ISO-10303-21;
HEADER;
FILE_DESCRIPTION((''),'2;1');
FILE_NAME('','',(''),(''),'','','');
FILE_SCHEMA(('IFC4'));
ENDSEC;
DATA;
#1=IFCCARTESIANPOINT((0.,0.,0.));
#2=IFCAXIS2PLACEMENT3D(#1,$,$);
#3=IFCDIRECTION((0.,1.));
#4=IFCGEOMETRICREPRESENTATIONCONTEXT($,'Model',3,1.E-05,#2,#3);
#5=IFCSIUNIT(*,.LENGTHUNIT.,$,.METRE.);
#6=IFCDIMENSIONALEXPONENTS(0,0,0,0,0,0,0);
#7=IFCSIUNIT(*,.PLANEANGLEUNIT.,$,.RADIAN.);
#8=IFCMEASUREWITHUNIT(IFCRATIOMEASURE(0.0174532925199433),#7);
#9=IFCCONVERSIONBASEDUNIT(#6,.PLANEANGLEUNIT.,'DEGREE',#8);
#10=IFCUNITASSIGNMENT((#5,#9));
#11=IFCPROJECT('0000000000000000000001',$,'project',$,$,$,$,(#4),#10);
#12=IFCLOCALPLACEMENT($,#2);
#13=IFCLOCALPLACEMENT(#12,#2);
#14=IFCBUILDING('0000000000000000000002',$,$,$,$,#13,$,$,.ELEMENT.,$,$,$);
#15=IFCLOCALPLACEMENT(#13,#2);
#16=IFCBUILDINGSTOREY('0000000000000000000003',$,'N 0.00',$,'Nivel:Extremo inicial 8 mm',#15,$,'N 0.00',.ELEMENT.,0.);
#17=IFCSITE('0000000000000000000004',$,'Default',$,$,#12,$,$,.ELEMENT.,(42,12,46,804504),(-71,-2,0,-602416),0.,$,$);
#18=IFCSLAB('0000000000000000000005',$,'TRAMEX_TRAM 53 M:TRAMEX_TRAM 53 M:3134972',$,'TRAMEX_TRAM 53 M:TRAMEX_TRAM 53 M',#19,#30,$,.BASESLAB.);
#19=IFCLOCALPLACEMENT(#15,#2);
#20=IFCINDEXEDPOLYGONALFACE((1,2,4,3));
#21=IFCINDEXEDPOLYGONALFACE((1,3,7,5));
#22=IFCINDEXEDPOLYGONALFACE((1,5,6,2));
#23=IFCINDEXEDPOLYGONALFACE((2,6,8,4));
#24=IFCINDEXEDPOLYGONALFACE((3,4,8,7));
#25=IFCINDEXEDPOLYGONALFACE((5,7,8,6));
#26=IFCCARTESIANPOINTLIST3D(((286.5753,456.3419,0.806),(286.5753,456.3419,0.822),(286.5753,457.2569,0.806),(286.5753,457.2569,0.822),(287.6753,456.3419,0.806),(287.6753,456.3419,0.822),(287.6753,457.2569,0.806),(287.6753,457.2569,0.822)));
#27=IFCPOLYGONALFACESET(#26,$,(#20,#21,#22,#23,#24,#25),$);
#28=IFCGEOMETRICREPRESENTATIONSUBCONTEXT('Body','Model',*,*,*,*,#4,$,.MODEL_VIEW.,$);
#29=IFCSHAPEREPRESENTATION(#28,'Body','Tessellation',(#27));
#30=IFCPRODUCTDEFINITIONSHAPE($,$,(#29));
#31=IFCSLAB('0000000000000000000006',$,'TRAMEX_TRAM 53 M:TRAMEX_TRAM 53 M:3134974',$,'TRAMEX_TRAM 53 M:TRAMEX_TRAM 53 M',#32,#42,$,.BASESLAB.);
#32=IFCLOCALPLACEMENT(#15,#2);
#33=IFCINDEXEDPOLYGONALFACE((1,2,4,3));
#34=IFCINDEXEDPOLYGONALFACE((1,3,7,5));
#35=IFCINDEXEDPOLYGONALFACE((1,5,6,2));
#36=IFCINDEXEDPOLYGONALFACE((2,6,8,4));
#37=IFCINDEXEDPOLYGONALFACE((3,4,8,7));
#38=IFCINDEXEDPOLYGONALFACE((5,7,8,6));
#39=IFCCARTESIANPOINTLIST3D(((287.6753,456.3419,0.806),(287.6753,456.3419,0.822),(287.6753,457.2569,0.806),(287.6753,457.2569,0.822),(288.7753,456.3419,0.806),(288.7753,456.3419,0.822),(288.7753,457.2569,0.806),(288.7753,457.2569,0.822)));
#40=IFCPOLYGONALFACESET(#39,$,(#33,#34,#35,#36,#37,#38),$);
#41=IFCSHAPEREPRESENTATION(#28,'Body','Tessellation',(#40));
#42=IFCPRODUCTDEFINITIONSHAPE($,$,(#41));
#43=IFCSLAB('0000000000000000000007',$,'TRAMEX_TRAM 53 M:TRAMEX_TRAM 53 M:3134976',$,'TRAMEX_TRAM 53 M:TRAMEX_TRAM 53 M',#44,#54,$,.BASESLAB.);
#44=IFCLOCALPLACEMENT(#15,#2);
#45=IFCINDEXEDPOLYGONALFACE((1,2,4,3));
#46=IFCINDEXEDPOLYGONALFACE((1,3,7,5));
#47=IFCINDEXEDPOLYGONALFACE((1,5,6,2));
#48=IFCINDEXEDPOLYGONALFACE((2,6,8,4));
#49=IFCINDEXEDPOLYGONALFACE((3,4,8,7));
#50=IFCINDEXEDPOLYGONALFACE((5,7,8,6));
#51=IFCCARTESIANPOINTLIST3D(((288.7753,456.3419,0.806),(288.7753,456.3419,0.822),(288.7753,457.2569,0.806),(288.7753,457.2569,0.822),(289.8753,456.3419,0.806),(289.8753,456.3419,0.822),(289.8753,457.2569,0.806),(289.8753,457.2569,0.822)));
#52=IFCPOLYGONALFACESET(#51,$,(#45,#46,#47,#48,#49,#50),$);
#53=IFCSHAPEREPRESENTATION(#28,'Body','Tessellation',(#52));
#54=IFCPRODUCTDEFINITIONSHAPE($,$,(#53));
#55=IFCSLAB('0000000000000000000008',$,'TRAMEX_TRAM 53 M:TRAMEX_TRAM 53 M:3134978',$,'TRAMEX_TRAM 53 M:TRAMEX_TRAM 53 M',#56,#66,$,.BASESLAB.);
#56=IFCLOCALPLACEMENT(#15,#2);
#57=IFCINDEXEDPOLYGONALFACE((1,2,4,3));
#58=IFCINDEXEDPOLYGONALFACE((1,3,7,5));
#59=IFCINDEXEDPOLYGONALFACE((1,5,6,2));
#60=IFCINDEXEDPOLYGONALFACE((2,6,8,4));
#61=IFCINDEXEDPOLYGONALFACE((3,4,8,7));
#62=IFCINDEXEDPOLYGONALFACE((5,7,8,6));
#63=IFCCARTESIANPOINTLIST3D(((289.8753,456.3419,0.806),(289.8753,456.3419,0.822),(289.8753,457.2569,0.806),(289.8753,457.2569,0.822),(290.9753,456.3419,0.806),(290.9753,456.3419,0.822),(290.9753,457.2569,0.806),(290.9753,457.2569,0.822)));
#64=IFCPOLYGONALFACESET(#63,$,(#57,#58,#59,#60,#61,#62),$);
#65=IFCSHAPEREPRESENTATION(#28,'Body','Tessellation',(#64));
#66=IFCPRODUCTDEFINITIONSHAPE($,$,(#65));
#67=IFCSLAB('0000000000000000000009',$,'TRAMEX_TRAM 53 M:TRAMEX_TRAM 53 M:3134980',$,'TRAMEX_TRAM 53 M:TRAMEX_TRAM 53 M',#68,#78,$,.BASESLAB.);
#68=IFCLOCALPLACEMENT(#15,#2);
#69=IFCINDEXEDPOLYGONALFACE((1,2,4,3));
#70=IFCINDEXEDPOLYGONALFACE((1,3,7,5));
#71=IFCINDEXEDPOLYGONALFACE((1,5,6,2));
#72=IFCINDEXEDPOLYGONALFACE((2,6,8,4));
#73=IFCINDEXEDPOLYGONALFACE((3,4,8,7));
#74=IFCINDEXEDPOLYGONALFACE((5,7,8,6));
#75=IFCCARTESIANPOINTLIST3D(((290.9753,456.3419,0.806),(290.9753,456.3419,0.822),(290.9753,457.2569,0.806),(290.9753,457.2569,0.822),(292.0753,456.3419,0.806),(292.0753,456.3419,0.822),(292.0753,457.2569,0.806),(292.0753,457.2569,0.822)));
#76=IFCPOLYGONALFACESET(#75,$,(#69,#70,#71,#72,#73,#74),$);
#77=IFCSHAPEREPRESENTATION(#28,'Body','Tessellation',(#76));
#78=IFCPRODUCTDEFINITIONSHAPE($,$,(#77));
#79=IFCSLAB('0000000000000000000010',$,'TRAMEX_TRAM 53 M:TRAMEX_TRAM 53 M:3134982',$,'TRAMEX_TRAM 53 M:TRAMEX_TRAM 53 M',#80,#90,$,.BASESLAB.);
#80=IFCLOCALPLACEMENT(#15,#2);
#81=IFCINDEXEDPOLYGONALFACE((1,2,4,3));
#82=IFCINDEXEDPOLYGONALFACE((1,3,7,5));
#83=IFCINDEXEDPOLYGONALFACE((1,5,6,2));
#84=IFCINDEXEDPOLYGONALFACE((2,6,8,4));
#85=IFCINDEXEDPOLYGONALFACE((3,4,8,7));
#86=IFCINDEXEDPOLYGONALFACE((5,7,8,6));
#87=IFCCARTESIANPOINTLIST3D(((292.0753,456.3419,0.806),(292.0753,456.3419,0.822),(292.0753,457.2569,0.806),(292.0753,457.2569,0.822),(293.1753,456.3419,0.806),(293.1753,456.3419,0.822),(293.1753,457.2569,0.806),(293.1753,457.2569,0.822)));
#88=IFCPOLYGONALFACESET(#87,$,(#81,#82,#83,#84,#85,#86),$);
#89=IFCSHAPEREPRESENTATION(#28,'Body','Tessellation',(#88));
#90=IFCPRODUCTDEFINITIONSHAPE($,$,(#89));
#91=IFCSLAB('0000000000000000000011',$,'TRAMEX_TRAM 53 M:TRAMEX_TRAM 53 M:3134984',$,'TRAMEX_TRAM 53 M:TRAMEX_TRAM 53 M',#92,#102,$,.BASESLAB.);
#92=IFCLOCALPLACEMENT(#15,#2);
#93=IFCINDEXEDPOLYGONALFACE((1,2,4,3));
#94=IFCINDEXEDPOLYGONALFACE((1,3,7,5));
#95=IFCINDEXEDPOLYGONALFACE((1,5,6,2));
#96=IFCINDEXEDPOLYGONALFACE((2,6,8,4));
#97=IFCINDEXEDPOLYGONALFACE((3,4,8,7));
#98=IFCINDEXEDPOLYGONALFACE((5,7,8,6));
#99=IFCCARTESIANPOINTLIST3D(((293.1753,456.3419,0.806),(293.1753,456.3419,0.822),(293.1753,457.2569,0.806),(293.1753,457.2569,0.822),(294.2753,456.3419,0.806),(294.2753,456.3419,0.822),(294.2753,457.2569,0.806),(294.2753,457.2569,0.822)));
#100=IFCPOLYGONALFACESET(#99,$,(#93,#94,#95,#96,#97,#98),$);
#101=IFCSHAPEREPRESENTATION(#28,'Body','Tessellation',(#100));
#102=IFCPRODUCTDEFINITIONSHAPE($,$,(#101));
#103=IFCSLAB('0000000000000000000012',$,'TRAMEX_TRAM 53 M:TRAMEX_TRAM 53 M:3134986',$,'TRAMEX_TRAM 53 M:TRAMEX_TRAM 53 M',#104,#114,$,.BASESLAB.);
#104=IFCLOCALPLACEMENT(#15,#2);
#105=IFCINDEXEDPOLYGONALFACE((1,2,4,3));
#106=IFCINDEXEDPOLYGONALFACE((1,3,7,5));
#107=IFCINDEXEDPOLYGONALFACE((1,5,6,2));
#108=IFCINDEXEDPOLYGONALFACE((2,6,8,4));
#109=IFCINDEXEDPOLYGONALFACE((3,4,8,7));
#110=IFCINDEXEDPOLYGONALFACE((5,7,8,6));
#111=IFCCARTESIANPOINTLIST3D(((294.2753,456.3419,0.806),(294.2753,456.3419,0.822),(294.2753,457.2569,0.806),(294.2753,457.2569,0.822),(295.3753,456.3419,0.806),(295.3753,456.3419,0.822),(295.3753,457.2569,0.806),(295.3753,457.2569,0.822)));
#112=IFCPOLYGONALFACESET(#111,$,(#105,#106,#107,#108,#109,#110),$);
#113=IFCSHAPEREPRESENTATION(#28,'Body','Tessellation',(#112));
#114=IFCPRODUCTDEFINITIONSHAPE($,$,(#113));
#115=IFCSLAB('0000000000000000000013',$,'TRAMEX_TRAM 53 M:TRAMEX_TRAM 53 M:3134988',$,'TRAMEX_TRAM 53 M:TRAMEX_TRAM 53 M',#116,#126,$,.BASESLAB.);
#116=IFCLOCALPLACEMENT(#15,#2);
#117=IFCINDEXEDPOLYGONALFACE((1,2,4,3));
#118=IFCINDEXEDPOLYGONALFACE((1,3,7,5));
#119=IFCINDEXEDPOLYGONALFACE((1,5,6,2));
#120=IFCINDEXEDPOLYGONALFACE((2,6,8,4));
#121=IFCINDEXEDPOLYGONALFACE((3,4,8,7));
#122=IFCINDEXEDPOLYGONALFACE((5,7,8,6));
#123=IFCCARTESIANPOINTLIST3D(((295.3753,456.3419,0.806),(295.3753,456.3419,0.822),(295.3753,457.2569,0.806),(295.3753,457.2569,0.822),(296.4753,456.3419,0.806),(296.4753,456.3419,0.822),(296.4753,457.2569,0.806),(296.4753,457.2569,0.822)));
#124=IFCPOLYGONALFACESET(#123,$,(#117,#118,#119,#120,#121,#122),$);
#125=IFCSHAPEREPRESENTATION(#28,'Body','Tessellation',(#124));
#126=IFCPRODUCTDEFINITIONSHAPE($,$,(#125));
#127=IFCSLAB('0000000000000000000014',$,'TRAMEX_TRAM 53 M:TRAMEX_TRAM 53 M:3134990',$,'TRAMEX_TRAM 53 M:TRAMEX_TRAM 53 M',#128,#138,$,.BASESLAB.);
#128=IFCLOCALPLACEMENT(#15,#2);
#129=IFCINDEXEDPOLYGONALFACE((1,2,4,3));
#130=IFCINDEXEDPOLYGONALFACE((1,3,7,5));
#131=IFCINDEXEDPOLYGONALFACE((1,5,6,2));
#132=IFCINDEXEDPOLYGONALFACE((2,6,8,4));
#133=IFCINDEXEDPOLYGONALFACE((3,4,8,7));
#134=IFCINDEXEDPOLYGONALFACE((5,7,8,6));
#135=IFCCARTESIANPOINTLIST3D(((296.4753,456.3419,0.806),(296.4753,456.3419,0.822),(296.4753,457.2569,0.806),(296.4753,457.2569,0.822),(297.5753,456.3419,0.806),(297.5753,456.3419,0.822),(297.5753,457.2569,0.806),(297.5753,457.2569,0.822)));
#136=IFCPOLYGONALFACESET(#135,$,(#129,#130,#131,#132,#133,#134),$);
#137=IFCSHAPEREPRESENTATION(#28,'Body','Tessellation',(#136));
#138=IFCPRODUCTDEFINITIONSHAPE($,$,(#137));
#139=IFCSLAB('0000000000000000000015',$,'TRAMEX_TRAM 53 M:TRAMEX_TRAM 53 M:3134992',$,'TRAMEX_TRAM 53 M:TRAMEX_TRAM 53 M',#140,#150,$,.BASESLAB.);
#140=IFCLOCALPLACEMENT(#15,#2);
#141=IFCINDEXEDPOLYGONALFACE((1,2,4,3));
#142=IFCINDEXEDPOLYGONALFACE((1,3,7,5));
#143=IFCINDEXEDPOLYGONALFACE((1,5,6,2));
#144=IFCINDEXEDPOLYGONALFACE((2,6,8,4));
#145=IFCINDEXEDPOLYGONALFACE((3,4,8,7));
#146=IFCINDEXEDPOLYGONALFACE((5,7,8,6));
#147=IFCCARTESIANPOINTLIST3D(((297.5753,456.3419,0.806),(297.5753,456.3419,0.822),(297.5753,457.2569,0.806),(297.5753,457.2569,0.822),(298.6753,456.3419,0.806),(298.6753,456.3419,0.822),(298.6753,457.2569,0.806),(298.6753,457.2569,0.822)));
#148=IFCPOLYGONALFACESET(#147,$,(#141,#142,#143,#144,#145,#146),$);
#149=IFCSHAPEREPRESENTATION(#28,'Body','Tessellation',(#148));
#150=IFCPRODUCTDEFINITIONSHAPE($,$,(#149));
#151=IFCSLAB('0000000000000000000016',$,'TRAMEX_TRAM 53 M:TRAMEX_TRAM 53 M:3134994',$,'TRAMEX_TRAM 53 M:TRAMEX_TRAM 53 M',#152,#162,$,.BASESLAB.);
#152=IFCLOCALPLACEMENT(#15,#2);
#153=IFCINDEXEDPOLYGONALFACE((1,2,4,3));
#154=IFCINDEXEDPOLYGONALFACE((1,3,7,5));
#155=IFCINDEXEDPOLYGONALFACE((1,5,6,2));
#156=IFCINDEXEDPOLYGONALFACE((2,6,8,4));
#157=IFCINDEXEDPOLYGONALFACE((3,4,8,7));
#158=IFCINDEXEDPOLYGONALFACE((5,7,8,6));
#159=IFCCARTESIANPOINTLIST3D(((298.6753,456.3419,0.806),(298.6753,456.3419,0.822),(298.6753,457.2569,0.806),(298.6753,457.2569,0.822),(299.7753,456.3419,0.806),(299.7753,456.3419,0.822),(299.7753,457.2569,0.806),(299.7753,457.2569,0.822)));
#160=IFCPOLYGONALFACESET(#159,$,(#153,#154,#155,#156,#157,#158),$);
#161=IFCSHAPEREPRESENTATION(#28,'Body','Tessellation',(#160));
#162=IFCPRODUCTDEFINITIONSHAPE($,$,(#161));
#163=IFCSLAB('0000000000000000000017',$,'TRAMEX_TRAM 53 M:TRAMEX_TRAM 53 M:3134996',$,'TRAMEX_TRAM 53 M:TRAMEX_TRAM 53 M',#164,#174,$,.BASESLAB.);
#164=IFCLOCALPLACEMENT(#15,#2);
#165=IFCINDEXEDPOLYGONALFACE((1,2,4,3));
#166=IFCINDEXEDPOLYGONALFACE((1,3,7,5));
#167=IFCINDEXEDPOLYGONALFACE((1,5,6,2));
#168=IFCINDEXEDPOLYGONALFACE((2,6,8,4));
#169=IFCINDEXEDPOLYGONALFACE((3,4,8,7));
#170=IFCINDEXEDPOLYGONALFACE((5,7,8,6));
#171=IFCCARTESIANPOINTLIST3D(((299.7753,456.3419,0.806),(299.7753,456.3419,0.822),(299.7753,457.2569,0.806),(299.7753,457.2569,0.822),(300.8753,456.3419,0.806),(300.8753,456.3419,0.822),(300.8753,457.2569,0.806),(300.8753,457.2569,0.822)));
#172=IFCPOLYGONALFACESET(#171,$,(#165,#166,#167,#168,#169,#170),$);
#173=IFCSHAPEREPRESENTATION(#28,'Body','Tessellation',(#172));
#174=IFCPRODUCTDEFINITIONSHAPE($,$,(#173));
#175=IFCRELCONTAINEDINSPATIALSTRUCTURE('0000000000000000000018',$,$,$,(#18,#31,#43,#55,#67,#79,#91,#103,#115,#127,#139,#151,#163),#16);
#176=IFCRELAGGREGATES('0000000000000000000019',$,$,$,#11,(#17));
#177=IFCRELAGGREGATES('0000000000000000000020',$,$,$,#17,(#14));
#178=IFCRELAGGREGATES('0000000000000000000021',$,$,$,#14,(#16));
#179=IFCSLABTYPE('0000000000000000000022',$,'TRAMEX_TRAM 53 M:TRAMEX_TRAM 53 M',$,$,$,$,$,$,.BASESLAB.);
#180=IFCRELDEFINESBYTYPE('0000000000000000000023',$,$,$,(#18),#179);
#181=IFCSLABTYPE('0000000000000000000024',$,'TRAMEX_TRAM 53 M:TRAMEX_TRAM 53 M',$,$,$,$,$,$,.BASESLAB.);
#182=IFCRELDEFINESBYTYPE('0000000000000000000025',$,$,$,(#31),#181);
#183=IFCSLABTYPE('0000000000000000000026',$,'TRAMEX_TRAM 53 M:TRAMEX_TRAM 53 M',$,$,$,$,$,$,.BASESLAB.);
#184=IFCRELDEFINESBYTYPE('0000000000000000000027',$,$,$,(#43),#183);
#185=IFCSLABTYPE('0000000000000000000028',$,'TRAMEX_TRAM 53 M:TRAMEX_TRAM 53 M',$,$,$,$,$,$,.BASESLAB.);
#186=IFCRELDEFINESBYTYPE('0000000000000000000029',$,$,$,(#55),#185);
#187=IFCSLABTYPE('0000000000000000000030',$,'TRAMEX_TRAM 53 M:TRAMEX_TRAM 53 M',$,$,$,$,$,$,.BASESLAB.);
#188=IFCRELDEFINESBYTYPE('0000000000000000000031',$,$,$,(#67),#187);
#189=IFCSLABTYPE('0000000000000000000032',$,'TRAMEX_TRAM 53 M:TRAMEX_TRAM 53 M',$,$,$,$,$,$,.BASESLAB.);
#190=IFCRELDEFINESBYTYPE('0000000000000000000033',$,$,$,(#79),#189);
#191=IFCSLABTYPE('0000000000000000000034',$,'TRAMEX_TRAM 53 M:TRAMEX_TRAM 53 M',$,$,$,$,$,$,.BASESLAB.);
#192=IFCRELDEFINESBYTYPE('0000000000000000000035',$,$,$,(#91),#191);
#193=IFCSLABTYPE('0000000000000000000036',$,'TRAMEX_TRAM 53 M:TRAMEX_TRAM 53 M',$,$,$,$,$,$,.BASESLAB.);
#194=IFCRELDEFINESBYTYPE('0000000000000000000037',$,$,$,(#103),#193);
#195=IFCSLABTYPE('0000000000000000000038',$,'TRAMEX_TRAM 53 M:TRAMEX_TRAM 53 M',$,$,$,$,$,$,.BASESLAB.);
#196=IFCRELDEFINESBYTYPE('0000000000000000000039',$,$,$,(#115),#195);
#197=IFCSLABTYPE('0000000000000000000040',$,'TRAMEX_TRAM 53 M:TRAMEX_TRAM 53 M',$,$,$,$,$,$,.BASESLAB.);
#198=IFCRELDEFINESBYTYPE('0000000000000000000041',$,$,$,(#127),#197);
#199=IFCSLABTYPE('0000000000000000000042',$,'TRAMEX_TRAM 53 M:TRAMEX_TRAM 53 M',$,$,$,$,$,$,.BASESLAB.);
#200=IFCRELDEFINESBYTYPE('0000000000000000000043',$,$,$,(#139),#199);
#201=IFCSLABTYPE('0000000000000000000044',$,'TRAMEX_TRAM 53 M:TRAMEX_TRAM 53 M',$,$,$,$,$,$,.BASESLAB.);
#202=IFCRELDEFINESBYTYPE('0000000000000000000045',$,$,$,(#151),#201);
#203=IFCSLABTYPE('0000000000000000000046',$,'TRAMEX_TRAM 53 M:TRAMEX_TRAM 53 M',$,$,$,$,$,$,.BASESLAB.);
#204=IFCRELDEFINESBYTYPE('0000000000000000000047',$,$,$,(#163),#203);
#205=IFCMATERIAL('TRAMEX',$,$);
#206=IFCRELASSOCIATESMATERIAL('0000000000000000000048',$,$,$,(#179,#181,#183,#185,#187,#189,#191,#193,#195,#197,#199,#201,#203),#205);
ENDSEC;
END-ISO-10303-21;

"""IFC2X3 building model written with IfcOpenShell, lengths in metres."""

from ifc_helpers import new_model, entity, si_unit, converted_unit, direction, frame, frame_2d, origin, place, context, subcontext, project, spatial, rectangle, extrude, material, type_object, element, save


model = new_model("IFC2X3")

# Units and contexts
model_context = context("Model", 3, precision=1e-05, world=origin(), true_north=direction((0.0, 1.0)))
body_context = subcontext(model_context, "Body", "Model", "MODEL_VIEW")
ifc_project = project(units=[si_unit("LENGTHUNIT", "METRE"), converted_unit("PLANEANGLEUNIT", "DEGREE", entity("IfcRatioMeasure", 0.0174532925199433), si_unit("PLANEANGLEUNIT", "RADIAN"), dimensions=[0, 0, 0, 0, 0, 0, 0])], contexts=[model_context])

# Site, building, storey
site_placement = place(None, origin())
site = spatial("IfcSite", under=ifc_project, at=site_placement, Name="Default", CompositionType="ELEMENT", RefLatitude=(42, 12, 46, 804504), RefLongitude=(-71, -2, 0, -602416), RefElevation=0.0)
building_placement = place(site_placement, origin())
building = spatial("IfcBuilding", under=site, at=building_placement, CompositionType="ELEMENT")
storey_placement = place(building_placement, origin())
storey = spatial("IfcBuildingStorey", under=building, at=storey_placement, Name="N 0.00", ObjectType="Nivel:Extremo inicial 8 mm", LongName="N 0.00", CompositionType="ELEMENT", Elevation=0.0)

# Slabs
ifc_material = material(Name="TRAMEX")
slab_type_1 = type_object("IfcSlabType", Name="TRAMEX_TRAM 53 M:TRAMEX_TRAM 53 M", PredefinedType="BASESLAB", material=ifc_material)
slab_1_placement = place(storey_placement, origin())
element("IfcSlab", 1, at=slab_1_placement, inside=storey, type_object=slab_type_1, Name="TRAMEX_TRAM 53 M:TRAMEX_TRAM 53 M:3134972", ObjectType="TRAMEX_TRAM 53 M:TRAMEX_TRAM 53 M", PredefinedType="BASESLAB", context=body_context, shape_type="SweptSolid", body=[
    extrude(rectangle(XDim=1.1, YDim=0.915, at=frame_2d((0.0, 0.0), x_axis=(1.0, 0.0))), frame((287.1253, 456.7994, 0.806), z_axis=(0.0, 0.0, 1.0), x_axis=(-1.0, 0.0, 0.0)), (0.0, 0.0, 1.0), 0.016),
])
slab_type_2 = type_object("IfcSlabType", Name="TRAMEX_TRAM 53 M:TRAMEX_TRAM 53 M", PredefinedType="BASESLAB", material=ifc_material)
slab_2_placement = place(storey_placement, origin())
element("IfcSlab", 2, at=slab_2_placement, inside=storey, type_object=slab_type_2, Name="TRAMEX_TRAM 53 M:TRAMEX_TRAM 53 M:3134974", ObjectType="TRAMEX_TRAM 53 M:TRAMEX_TRAM 53 M", PredefinedType="BASESLAB", context=body_context, shape_type="SweptSolid", body=[
    extrude(rectangle(XDim=1.1, YDim=0.915, at=frame_2d((0.0, 0.0), x_axis=(1.0, 0.0))), frame((288.2253, 456.7994, 0.806), z_axis=(0.0, 0.0, 1.0), x_axis=(-1.0, 0.0, 0.0)), (0.0, 0.0, 1.0), 0.016),
])
slab_type_3 = type_object("IfcSlabType", Name="TRAMEX_TRAM 53 M:TRAMEX_TRAM 53 M", PredefinedType="BASESLAB", material=ifc_material)
slab_3_placement = place(storey_placement, origin())
element("IfcSlab", 3, at=slab_3_placement, inside=storey, type_object=slab_type_3, Name="TRAMEX_TRAM 53 M:TRAMEX_TRAM 53 M:3134976", ObjectType="TRAMEX_TRAM 53 M:TRAMEX_TRAM 53 M", PredefinedType="BASESLAB", context=body_context, shape_type="SweptSolid", body=[
    extrude(rectangle(XDim=1.1, YDim=0.915, at=frame_2d((0.0, 0.0), x_axis=(1.0, 0.0))), frame((289.3253, 456.7994, 0.806), z_axis=(0.0, 0.0, 1.0), x_axis=(-1.0, 0.0, 0.0)), (0.0, 0.0, 1.0), 0.016),
])
slab_type_4 = type_object("IfcSlabType", Name="TRAMEX_TRAM 53 M:TRAMEX_TRAM 53 M", PredefinedType="BASESLAB", material=ifc_material)
slab_4_placement = place(storey_placement, origin())
element("IfcSlab", 4, at=slab_4_placement, inside=storey, type_object=slab_type_4, Name="TRAMEX_TRAM 53 M:TRAMEX_TRAM 53 M:3134978", ObjectType="TRAMEX_TRAM 53 M:TRAMEX_TRAM 53 M", PredefinedType="BASESLAB", context=body_context, shape_type="SweptSolid", body=[
    extrude(rectangle(XDim=1.1, YDim=0.915, at=frame_2d((0.0, 0.0), x_axis=(1.0, 0.0))), frame((290.4253, 456.7994, 0.806), z_axis=(0.0, 0.0, 1.0), x_axis=(-1.0, 0.0, 0.0)), (0.0, 0.0, 1.0), 0.016),
])
slab_type_5 = type_object("IfcSlabType", Name="TRAMEX_TRAM 53 M:TRAMEX_TRAM 53 M", PredefinedType="BASESLAB", material=ifc_material)
slab_5_placement = place(storey_placement, origin())
element("IfcSlab", 5, at=slab_5_placement, inside=storey, type_object=slab_type_5, Name="TRAMEX_TRAM 53 M:TRAMEX_TRAM 53 M:3134980", ObjectType="TRAMEX_TRAM 53 M:TRAMEX_TRAM 53 M", PredefinedType="BASESLAB", context=body_context, shape_type="SweptSolid", body=[
    extrude(rectangle(XDim=1.1, YDim=0.915, at=frame_2d((0.0, 0.0), x_axis=(1.0, 0.0))), frame((291.5253, 456.7994, 0.806), z_axis=(0.0, 0.0, 1.0), x_axis=(-1.0, 0.0, 0.0)), (0.0, 0.0, 1.0), 0.016),
])
slab_type_6 = type_object("IfcSlabType", Name="TRAMEX_TRAM 53 M:TRAMEX_TRAM 53 M", PredefinedType="BASESLAB", material=ifc_material)
slab_6_placement = place(storey_placement, origin())
element("IfcSlab", 6, at=slab_6_placement, inside=storey, type_object=slab_type_6, Name="TRAMEX_TRAM 53 M:TRAMEX_TRAM 53 M:3134982", ObjectType="TRAMEX_TRAM 53 M:TRAMEX_TRAM 53 M", PredefinedType="BASESLAB", context=body_context, shape_type="SweptSolid", body=[
    extrude(rectangle(XDim=1.1, YDim=0.915, at=frame_2d((0.0, 0.0), x_axis=(1.0, 0.0))), frame((292.6253, 456.7994, 0.806), z_axis=(0.0, 0.0, 1.0), x_axis=(-1.0, 0.0, 0.0)), (0.0, 0.0, 1.0), 0.016),
])
slab_type_7 = type_object("IfcSlabType", Name="TRAMEX_TRAM 53 M:TRAMEX_TRAM 53 M", PredefinedType="BASESLAB", material=ifc_material)
slab_7_placement = place(storey_placement, origin())
element("IfcSlab", 7, at=slab_7_placement, inside=storey, type_object=slab_type_7, Name="TRAMEX_TRAM 53 M:TRAMEX_TRAM 53 M:3134984", ObjectType="TRAMEX_TRAM 53 M:TRAMEX_TRAM 53 M", PredefinedType="BASESLAB", context=body_context, shape_type="SweptSolid", body=[
    extrude(rectangle(XDim=1.1, YDim=0.915, at=frame_2d((0.0, 0.0), x_axis=(1.0, 0.0))), frame((293.7253, 456.7994, 0.806), z_axis=(0.0, 0.0, 1.0), x_axis=(-1.0, 0.0, 0.0)), (0.0, 0.0, 1.0), 0.016),
])
slab_type_8 = type_object("IfcSlabType", Name="TRAMEX_TRAM 53 M:TRAMEX_TRAM 53 M", PredefinedType="BASESLAB", material=ifc_material)
slab_8_placement = place(storey_placement, origin())
element("IfcSlab", 8, at=slab_8_placement, inside=storey, type_object=slab_type_8, Name="TRAMEX_TRAM 53 M:TRAMEX_TRAM 53 M:3134986", ObjectType="TRAMEX_TRAM 53 M:TRAMEX_TRAM 53 M", PredefinedType="BASESLAB", context=body_context, shape_type="SweptSolid", body=[
    extrude(rectangle(XDim=1.1, YDim=0.915, at=frame_2d((0.0, 0.0), x_axis=(1.0, 0.0))), frame((294.8253, 456.7994, 0.806), z_axis=(0.0, 0.0, 1.0), x_axis=(-1.0, 0.0, 0.0)), (0.0, 0.0, 1.0), 0.016),
])
slab_type_9 = type_object("IfcSlabType", Name="TRAMEX_TRAM 53 M:TRAMEX_TRAM 53 M", PredefinedType="BASESLAB", material=ifc_material)
slab_9_placement = place(storey_placement, origin())
element("IfcSlab", 9, at=slab_9_placement, inside=storey, type_object=slab_type_9, Name="TRAMEX_TRAM 53 M:TRAMEX_TRAM 53 M:3134988", ObjectType="TRAMEX_TRAM 53 M:TRAMEX_TRAM 53 M", PredefinedType="BASESLAB", context=body_context, shape_type="SweptSolid", body=[
    extrude(rectangle(XDim=1.1, YDim=0.915, at=frame_2d((0.0, 0.0), x_axis=(1.0, 0.0))), frame((295.9253, 456.7994, 0.806), z_axis=(0.0, 0.0, 1.0), x_axis=(-1.0, 0.0, 0.0)), (0.0, 0.0, 1.0), 0.016),
])
slab_type_10 = type_object("IfcSlabType", Name="TRAMEX_TRAM 53 M:TRAMEX_TRAM 53 M", PredefinedType="BASESLAB", material=ifc_material)
slab_10_placement = place(storey_placement, origin())
element("IfcSlab", 10, at=slab_10_placement, inside=storey, type_object=slab_type_10, Name="TRAMEX_TRAM 53 M:TRAMEX_TRAM 53 M:3134990", ObjectType="TRAMEX_TRAM 53 M:TRAMEX_TRAM 53 M", PredefinedType="BASESLAB", context=body_context, shape_type="SweptSolid", body=[
    extrude(rectangle(XDim=1.1, YDim=0.915, at=frame_2d((0.0, 0.0), x_axis=(1.0, 0.0))), frame((297.0253, 456.7994, 0.806), z_axis=(0.0, 0.0, 1.0), x_axis=(-1.0, 0.0, 0.0)), (0.0, 0.0, 1.0), 0.016),
])
slab_type_11 = type_object("IfcSlabType", Name="TRAMEX_TRAM 53 M:TRAMEX_TRAM 53 M", PredefinedType="BASESLAB", material=ifc_material)
slab_11_placement = place(storey_placement, origin())
element("IfcSlab", 11, at=slab_11_placement, inside=storey, type_object=slab_type_11, Name="TRAMEX_TRAM 53 M:TRAMEX_TRAM 53 M:3134992", ObjectType="TRAMEX_TRAM 53 M:TRAMEX_TRAM 53 M", PredefinedType="BASESLAB", context=body_context, shape_type="SweptSolid", body=[
    extrude(rectangle(XDim=1.1, YDim=0.915, at=frame_2d((0.0, 0.0), x_axis=(1.0, 0.0))), frame((298.1253, 456.7994, 0.806), z_axis=(0.0, 0.0, 1.0), x_axis=(-1.0, 0.0, 0.0)), (0.0, 0.0, 1.0), 0.016),
])
slab_type_12 = type_object("IfcSlabType", Name="TRAMEX_TRAM 53 M:TRAMEX_TRAM 53 M", PredefinedType="BASESLAB", material=ifc_material)
slab_12_placement = place(storey_placement, origin())
element("IfcSlab", 12, at=slab_12_placement, inside=storey, type_object=slab_type_12, Name="TRAMEX_TRAM 53 M:TRAMEX_TRAM 53 M:3134994", ObjectType="TRAMEX_TRAM 53 M:TRAMEX_TRAM 53 M", PredefinedType="BASESLAB", context=body_context, shape_type="SweptSolid", body=[
    extrude(rectangle(XDim=1.1, YDim=0.915, at=frame_2d((0.0, 0.0), x_axis=(1.0, 0.0))), frame((299.2253, 456.7994, 0.806), z_axis=(0.0, 0.0, 1.0), x_axis=(-1.0, 0.0, 0.0)), (0.0, 0.0, 1.0), 0.016),
])
slab_type_13 = type_object("IfcSlabType", Name="TRAMEX_TRAM 53 M:TRAMEX_TRAM 53 M", PredefinedType="BASESLAB", material=ifc_material)
slab_13_placement = place(storey_placement, origin())
element("IfcSlab", 13, at=slab_13_placement, inside=storey, type_object=slab_type_13, Name="TRAMEX_TRAM 53 M:TRAMEX_TRAM 53 M:3134996", ObjectType="TRAMEX_TRAM 53 M:TRAMEX_TRAM 53 M", PredefinedType="BASESLAB", context=body_context, shape_type="SweptSolid", body=[
    extrude(rectangle(XDim=1.1, YDim=0.915, at=frame_2d((0.0, 0.0), x_axis=(1.0, 0.0))), frame((300.3253, 456.7994, 0.806), z_axis=(0.0, 0.0, 1.0), x_axis=(-1.0, 0.0, 0.0)), (0.0, 0.0, 1.0), 0.016),
])

save(model, "model.ifc")
